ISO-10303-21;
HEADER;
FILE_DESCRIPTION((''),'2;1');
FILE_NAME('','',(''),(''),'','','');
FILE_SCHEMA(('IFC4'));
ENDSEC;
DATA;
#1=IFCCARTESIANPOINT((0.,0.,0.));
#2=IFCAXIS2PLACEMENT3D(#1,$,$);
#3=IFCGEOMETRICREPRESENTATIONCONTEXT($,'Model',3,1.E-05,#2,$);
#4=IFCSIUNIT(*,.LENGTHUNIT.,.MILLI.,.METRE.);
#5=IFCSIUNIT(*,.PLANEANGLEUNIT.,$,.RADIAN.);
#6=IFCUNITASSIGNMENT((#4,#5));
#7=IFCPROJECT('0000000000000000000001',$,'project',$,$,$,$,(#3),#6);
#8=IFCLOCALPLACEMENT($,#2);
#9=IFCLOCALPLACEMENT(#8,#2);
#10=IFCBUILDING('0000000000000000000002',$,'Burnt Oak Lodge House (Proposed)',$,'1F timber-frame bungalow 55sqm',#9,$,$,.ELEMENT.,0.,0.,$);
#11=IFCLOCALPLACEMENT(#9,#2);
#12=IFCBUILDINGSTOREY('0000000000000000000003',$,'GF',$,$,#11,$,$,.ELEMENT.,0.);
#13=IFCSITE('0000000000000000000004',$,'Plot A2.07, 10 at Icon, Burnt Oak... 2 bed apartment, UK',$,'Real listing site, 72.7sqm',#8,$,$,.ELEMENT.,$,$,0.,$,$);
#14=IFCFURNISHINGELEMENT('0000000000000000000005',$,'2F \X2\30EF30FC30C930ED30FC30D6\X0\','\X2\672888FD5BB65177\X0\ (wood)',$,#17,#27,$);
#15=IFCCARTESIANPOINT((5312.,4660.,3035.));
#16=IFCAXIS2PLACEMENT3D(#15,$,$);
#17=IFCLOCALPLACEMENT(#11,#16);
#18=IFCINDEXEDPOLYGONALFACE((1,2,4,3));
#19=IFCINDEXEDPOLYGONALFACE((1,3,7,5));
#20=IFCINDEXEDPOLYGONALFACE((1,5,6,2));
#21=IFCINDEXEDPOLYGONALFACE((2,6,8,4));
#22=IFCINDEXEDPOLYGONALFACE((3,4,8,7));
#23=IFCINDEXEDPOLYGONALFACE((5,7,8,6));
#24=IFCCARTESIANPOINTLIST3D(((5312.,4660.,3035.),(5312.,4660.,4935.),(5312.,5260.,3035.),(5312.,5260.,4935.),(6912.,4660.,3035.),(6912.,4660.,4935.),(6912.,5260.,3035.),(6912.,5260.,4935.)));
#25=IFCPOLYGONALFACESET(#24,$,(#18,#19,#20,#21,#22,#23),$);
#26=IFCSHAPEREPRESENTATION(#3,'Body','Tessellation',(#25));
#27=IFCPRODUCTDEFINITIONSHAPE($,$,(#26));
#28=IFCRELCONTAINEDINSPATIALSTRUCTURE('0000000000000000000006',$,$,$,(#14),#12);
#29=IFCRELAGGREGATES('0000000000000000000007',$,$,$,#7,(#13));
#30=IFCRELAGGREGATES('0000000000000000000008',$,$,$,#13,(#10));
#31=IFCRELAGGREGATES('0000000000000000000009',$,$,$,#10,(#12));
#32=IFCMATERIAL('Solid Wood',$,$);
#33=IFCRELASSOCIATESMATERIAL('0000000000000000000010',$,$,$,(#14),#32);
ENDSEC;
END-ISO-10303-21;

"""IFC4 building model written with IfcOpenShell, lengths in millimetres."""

from ifc_helpers import new_model, si_unit, frame, frame_2d, origin, place, context, project, spatial, rectangle, extrude, material, element, save


model = new_model("IFC4")

# Units and contexts
model_context = context("Model", 3, precision=1e-05, world=origin())
ifc_project = project(units=[si_unit("LENGTHUNIT", "METRE", prefix="MILLI"), si_unit("PLANEANGLEUNIT", "RADIAN")], contexts=[model_context])

# Site, building, storey
site_placement = place(None, origin())
site = spatial("IfcSite", under=ifc_project, at=site_placement, Name="Plot A2.07, 10 at Icon, Burnt Oak... 2 bed apartment, UK", ObjectType="Real listing site, 72.7sqm", CompositionType="ELEMENT", RefElevation=0.0)
building_placement = place(site_placement, origin())
building = spatial("IfcBuilding", under=site, at=building_placement, Name="Burnt Oak Lodge House (Proposed)", ObjectType="1F timber-frame bungalow 55sqm", CompositionType="ELEMENT", ElevationOfRefHeight=0.0, ElevationOfTerrain=0.0)
storey_placement = place(building_placement, origin())
storey = spatial("IfcBuildingStorey", under=building, at=storey_placement, Name="GF", CompositionType="ELEMENT", Elevation=0.0)

# Shared definitions
ifc_material_1 = material(Name="Solid Wood")

# Furnishing element
furnishing_1_placement = place(storey_placement, frame((5312.0, 4660.0, 3035.0)))
element("IfcFurnishingElement", 1, at=furnishing_1_placement, inside=storey, material=ifc_material_1, Name="2F ワードローブ", Description="木製家具 (wood)", context=model_context, shape_type="SweptSolid", body=[
    extrude(rectangle(XDim=1600.0, YDim=600.0, at=frame_2d((800.0, 300.0))), frame((5312.0, 4660.0, 3035.0)), (0.0, 0.0, 1.0), 1900.0),
])

save(model, "model.ifc")
